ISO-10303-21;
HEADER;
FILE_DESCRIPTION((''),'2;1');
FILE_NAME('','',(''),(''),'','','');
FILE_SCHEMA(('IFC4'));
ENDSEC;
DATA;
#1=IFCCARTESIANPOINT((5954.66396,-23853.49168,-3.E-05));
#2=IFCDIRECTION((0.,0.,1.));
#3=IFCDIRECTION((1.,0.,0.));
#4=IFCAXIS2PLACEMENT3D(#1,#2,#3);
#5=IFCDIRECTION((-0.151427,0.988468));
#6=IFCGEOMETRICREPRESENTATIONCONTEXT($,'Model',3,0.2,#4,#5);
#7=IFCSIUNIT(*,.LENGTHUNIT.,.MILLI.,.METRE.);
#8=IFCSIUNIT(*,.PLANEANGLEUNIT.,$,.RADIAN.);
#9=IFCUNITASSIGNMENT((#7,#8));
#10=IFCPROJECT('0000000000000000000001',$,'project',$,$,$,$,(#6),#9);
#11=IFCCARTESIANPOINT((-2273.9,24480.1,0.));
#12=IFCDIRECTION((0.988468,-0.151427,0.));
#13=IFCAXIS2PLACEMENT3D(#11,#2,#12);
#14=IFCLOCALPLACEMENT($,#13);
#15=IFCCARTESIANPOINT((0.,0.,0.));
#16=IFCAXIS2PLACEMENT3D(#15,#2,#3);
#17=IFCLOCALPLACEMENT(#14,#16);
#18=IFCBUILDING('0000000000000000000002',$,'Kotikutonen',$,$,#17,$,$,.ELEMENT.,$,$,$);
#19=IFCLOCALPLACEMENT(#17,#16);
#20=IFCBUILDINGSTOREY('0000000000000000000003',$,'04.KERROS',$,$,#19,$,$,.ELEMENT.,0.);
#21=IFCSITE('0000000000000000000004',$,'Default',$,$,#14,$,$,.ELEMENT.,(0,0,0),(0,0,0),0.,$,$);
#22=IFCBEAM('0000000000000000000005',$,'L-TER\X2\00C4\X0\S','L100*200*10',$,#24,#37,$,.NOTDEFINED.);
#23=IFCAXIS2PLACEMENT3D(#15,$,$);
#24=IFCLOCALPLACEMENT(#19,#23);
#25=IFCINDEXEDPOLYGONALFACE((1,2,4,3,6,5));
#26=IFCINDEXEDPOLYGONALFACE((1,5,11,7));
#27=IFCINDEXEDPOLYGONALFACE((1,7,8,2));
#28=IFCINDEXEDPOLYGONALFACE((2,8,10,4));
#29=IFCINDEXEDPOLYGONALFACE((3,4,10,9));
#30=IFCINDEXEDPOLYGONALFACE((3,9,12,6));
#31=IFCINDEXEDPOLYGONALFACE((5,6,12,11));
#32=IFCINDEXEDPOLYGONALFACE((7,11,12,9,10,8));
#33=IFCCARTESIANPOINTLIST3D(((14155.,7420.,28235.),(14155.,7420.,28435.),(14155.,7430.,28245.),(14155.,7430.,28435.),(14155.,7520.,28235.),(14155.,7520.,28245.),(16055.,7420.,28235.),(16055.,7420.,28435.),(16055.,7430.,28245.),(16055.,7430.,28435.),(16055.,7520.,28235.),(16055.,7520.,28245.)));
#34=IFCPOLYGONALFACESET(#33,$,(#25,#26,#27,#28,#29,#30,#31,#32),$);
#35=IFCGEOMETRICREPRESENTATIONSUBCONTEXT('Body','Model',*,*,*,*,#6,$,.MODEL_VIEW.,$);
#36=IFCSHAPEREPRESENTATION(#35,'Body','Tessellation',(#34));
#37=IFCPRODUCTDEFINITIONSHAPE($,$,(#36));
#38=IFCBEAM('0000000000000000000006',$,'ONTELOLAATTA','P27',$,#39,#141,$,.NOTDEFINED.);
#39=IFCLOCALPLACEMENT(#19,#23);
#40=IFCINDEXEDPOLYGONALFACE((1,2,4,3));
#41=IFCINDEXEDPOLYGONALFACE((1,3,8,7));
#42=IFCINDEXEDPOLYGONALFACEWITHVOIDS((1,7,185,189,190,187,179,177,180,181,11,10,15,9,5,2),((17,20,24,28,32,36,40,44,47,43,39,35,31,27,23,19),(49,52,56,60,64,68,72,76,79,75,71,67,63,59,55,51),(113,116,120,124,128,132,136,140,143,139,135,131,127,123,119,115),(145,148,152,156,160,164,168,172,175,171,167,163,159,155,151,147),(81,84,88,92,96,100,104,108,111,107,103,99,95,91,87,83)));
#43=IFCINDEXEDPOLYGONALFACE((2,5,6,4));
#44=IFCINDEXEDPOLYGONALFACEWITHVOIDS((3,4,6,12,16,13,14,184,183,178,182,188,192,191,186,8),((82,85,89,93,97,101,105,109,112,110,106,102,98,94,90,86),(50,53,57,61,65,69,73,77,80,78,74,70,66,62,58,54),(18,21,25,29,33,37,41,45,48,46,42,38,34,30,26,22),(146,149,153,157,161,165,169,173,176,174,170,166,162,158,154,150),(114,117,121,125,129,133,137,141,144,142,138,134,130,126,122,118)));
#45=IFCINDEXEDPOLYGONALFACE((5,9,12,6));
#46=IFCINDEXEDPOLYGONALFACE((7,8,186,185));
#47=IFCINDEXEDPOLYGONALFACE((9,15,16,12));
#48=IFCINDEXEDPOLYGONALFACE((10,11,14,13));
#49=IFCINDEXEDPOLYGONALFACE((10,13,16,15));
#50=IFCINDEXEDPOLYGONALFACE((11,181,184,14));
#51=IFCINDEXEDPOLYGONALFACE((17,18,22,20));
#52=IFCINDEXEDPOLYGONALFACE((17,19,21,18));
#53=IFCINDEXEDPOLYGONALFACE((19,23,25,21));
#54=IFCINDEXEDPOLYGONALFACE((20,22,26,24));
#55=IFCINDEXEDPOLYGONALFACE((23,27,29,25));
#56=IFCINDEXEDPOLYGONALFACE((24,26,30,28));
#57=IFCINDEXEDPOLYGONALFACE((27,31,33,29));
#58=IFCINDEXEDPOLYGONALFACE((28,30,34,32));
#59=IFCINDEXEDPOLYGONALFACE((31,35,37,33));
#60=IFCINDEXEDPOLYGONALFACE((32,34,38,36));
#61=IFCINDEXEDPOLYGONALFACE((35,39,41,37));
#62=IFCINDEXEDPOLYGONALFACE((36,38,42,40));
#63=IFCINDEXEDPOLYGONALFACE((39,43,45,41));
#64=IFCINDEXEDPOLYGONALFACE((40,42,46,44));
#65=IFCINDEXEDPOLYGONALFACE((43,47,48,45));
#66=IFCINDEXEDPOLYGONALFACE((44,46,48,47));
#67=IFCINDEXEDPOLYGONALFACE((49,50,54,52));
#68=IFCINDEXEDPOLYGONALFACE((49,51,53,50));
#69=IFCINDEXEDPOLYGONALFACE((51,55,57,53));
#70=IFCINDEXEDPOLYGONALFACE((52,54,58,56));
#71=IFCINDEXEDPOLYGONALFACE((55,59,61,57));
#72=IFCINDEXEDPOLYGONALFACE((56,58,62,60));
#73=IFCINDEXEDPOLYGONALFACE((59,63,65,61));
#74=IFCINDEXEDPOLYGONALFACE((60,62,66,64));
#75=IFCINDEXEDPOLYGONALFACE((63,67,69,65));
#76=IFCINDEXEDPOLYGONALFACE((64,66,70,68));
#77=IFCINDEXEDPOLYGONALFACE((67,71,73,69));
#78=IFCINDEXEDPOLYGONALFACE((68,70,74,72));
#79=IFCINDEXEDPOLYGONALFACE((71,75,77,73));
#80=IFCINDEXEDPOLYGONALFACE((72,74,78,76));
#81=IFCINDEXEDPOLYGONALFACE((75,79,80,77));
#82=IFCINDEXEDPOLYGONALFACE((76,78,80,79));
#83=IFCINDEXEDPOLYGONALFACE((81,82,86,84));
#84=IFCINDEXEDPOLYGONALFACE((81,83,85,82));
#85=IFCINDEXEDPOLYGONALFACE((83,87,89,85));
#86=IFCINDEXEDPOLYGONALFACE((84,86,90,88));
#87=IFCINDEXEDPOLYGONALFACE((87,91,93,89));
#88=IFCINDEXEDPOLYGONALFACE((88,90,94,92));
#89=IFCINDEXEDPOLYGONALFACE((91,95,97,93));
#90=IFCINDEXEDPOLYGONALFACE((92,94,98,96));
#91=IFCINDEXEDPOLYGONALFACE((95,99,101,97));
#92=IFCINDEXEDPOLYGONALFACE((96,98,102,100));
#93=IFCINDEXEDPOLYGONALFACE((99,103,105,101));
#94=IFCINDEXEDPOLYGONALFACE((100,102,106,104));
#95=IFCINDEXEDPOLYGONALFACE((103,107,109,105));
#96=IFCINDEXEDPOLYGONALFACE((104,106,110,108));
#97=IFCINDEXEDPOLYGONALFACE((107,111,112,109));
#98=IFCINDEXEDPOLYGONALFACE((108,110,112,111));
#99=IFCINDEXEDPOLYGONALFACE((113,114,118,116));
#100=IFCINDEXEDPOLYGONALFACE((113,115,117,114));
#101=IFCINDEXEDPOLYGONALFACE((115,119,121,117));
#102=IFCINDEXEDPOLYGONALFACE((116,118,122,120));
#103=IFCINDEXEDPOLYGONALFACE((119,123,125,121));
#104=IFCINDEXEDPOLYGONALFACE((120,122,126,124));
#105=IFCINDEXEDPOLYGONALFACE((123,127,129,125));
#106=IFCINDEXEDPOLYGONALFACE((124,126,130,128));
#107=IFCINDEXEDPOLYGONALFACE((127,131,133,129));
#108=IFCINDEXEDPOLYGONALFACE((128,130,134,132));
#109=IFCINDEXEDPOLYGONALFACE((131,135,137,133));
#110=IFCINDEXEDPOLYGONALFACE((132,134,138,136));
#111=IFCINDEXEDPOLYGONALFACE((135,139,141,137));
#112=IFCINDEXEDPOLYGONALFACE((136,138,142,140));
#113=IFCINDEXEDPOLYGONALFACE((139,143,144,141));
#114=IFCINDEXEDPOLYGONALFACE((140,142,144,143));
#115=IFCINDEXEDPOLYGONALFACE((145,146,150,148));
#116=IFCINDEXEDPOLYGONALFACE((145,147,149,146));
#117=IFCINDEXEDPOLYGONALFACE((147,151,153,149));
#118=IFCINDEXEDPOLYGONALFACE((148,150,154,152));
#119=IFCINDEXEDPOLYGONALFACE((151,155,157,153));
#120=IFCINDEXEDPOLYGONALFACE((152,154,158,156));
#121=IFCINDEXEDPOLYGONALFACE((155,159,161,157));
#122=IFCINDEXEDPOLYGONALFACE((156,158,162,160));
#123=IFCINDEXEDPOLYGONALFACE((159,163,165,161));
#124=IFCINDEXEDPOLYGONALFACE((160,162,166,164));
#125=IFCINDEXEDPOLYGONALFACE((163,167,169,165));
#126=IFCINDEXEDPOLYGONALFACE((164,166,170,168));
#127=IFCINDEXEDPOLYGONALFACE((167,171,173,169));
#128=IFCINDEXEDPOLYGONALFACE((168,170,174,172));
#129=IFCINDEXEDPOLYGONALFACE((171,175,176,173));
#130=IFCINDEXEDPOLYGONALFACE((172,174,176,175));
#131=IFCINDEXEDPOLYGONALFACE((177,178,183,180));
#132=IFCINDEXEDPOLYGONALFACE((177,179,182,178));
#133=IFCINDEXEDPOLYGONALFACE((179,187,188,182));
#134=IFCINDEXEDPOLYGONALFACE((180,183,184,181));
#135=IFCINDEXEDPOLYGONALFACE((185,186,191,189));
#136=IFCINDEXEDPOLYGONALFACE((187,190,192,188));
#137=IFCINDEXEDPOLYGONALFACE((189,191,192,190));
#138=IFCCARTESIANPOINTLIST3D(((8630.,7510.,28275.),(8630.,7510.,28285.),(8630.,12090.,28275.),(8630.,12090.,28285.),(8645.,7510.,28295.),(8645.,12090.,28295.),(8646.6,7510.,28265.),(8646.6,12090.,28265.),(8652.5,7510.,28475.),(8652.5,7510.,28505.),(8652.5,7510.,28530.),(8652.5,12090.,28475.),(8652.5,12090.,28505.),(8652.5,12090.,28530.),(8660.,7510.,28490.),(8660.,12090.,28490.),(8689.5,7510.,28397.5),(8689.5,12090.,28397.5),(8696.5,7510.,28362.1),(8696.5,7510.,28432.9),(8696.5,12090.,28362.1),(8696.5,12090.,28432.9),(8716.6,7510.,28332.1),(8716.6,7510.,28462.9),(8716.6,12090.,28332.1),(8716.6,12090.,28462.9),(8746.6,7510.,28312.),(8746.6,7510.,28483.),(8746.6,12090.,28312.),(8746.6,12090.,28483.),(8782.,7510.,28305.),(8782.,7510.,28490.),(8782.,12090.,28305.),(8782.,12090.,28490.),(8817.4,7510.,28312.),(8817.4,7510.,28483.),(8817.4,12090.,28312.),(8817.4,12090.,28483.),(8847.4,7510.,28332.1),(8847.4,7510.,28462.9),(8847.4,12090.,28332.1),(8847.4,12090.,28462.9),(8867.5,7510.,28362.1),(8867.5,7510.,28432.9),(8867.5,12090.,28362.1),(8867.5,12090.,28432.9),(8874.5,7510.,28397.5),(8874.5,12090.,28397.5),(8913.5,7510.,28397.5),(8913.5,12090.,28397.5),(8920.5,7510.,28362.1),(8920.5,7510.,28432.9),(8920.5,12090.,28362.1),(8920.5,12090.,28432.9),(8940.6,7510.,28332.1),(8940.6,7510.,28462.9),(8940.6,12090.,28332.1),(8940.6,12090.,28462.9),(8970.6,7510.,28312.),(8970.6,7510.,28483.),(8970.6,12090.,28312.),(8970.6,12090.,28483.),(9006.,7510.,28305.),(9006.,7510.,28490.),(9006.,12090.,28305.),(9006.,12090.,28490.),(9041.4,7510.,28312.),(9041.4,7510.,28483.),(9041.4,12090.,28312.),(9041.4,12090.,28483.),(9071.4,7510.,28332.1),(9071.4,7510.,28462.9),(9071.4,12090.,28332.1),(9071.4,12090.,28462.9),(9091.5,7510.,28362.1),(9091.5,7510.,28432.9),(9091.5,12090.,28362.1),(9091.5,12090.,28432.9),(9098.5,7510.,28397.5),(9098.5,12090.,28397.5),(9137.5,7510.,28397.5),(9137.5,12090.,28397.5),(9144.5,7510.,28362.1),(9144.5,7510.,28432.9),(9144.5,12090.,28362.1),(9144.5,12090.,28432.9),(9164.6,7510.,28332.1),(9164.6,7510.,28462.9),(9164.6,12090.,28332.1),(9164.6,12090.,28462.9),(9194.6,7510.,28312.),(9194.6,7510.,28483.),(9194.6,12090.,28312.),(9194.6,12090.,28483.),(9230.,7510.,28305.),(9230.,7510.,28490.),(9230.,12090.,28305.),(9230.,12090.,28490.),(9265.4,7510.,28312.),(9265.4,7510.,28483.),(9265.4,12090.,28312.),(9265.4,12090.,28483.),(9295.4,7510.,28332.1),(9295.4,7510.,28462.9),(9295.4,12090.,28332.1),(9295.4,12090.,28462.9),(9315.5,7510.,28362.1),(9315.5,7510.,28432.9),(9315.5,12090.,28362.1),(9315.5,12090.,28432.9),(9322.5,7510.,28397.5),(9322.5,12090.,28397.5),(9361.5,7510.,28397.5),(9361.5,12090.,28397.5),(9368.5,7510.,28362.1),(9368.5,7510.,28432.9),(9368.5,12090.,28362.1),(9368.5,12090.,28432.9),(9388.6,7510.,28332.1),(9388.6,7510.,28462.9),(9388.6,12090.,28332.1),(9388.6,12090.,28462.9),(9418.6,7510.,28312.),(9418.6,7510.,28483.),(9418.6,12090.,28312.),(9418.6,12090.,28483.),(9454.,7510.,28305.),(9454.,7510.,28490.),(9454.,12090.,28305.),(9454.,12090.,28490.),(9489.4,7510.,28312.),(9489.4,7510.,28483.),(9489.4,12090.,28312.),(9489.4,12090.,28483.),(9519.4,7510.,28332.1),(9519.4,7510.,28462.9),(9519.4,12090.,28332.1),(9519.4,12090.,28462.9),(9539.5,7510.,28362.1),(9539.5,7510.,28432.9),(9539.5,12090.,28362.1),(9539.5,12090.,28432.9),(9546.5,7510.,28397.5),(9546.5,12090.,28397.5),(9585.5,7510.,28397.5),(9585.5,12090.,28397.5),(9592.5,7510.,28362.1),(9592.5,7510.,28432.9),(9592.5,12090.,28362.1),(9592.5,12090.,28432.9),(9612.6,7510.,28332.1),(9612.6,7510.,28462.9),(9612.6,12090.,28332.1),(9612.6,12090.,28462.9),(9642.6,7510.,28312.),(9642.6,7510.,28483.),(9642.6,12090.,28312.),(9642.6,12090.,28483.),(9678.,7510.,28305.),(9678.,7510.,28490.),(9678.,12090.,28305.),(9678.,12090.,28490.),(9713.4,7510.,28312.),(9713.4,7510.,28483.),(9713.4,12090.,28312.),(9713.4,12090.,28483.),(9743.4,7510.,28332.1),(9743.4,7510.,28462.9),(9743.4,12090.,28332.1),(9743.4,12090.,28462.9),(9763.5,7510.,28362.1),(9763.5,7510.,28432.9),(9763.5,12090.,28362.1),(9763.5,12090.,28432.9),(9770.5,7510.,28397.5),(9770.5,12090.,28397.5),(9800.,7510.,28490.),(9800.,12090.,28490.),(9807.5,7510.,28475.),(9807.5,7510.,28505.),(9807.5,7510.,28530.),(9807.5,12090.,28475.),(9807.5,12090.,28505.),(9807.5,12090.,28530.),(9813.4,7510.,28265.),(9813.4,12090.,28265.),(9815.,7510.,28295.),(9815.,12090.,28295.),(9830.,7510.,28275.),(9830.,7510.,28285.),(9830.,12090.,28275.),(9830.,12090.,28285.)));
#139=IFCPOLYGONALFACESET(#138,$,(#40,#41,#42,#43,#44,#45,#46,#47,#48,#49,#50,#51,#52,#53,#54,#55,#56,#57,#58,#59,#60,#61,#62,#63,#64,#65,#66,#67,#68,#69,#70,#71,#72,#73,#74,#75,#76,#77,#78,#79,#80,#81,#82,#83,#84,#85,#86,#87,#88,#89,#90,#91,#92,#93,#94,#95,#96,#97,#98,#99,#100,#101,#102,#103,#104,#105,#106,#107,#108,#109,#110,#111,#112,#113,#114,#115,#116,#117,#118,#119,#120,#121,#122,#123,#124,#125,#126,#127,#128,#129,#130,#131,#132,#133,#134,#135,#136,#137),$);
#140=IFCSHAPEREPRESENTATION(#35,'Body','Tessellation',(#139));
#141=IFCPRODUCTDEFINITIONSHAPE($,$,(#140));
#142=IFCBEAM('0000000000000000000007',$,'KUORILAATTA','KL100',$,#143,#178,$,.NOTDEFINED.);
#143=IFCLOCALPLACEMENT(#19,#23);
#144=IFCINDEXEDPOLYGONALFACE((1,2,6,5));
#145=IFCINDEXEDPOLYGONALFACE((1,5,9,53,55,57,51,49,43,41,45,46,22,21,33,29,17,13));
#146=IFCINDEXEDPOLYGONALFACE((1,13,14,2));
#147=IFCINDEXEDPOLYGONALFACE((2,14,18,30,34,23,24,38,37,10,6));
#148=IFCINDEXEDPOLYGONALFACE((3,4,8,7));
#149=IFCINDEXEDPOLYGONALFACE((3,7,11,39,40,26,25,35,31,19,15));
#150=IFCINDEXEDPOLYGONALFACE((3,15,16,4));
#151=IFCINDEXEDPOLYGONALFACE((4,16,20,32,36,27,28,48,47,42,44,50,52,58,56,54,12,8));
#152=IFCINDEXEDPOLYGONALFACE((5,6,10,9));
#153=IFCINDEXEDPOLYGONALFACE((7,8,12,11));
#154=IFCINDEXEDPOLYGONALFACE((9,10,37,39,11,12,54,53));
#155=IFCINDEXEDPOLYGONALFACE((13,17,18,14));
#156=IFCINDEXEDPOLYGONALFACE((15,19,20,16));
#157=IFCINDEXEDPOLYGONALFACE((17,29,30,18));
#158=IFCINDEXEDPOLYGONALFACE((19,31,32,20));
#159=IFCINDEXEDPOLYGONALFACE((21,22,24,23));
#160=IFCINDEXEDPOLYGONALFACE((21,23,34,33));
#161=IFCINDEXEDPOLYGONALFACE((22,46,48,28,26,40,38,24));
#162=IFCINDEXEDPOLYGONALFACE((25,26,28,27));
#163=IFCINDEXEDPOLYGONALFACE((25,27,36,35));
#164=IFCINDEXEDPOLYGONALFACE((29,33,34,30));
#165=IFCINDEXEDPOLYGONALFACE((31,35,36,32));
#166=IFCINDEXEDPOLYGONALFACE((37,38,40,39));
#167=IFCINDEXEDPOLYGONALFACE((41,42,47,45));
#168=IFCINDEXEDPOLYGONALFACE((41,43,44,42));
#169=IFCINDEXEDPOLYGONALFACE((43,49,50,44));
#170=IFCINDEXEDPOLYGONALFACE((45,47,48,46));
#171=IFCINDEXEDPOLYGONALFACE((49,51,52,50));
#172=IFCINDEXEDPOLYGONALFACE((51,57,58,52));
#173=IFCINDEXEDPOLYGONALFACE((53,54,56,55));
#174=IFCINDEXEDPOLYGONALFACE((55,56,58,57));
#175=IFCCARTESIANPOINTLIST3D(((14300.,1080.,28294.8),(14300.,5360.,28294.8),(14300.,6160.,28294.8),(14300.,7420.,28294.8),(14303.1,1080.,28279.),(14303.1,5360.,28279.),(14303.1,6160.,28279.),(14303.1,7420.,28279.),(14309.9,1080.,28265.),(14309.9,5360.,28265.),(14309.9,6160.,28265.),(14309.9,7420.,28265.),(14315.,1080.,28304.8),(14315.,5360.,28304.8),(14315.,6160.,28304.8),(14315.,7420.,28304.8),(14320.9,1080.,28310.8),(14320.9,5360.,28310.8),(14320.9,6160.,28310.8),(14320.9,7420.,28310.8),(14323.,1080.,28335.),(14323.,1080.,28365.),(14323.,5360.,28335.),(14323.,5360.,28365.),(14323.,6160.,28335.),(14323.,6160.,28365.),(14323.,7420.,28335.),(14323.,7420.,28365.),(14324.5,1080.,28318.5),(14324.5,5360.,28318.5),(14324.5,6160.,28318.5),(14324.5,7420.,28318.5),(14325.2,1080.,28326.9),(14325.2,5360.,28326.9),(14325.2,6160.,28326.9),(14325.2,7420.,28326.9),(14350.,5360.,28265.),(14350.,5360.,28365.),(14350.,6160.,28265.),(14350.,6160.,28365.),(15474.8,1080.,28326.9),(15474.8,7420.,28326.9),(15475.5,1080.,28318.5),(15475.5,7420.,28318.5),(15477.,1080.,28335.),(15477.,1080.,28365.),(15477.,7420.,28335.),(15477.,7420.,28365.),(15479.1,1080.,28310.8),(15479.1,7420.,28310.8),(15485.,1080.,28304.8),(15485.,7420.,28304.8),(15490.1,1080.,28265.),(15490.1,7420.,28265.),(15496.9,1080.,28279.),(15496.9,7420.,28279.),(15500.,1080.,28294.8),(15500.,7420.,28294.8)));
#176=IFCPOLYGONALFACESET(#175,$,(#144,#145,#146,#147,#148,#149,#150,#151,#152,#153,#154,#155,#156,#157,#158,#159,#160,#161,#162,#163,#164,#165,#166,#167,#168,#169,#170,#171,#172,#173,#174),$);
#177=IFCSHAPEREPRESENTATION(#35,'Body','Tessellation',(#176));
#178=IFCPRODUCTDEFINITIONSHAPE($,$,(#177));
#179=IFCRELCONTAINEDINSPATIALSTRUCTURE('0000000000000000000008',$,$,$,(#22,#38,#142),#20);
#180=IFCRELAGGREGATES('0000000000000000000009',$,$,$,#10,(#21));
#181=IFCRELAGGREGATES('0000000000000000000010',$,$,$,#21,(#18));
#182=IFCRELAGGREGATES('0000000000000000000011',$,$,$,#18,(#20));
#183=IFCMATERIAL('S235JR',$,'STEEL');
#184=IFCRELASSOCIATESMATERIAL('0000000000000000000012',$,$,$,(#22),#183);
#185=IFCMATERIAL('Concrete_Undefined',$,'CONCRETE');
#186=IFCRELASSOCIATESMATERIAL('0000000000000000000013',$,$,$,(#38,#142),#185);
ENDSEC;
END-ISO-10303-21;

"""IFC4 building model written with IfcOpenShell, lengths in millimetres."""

from ifc_helpers import new_model, si_unit, direction, frame, origin_with_axes, place, context, subcontext, project, spatial, line, indexed_curve, outline, extrude, material, element, save


model = new_model("IFC4")

# Units and contexts
model_context = context("Model", 3, precision=0.2, world=frame((5954.66396, -23853.49168, -3e-05), z_axis=(0.0, 0.0, 1.0), x_axis=(1.0, 0.0, 0.0)), true_north=direction((-0.151427, 0.988468)))
body_context = subcontext(model_context, "Body", "Model", "MODEL_VIEW")
ifc_project = project(units=[si_unit("LENGTHUNIT", "METRE", prefix="MILLI"), si_unit("PLANEANGLEUNIT", "RADIAN")], contexts=[model_context])

# Site, building, storey
site_placement = place(None, frame((-2273.9, 24480.1, 0.0), z_axis=(0.0, 0.0, 1.0), x_axis=(0.988468, -0.151427, 0.0)))
site = spatial("IfcSite", under=ifc_project, at=site_placement, Name="Default", CompositionType="ELEMENT", RefLatitude=(0, 0, 0), RefLongitude=(0, 0, 0), RefElevation=0.0)
building_placement = place(site_placement, origin_with_axes())
building = spatial("IfcBuilding", under=site, at=building_placement, Name="Kotikutonen", CompositionType="ELEMENT")
storey_placement = place(building_placement, origin_with_axes())
storey = spatial("IfcBuildingStorey", under=building, at=storey_placement, Name="04.KERROS", CompositionType="ELEMENT", Elevation=0.0)

# Beams
ifc_material_1 = material(Name="Concrete_Undefined", Category="CONCRETE")
ifc_material_2 = material(Name="S235JR", Category="STEEL")
for number, where, z_axis, x_axis, name in (
    (1, (14155.0, 7470.0, 28335.0), (0.0, 0.0, 1.0), (1.0, 0.0, 0.0), "L-TERÄS"),
):
    element("IfcBeam", number, at=place(storey_placement, frame(where, z_axis=z_axis, x_axis=x_axis)), inside=storey, material=ifc_material_2, Name=name, Description="L100*200*10", PredefinedType="NOTDEFINED", context=body_context, shape_type="SolidModel", body=[
        extrude(outline(indexed_curve([(-100.0, -50.0), (100.0, -50.0), (100.0, -40.0), (-90.0, -40.0), (-90.0, 50.0), (-100.0, 50.0)], segments=[line(1, 2, 3, 4, 5, 6, 1)])), frame((0.0, 0.0, 0.0), z_axis=(-1.0, 0.0, 0.0), x_axis=(0.0, 0.0, 1.0)), (0.0, 0.0, -1.0), 1900.0),
    ])
beam_1_placement = place(storey_placement, frame((9230.0, 12090.0, 28397.5), z_axis=(-1.0, 0.0, 0.0), x_axis=(0.0, -1.0, 0.0)))
element("IfcBeam", 2, at=beam_1_placement, inside=storey, material=ifc_material_1, Name="ONTELOLAATTA", Description="P27", PredefinedType="NOTDEFINED", context=body_context, shape_type="SolidModel", body=[
    extrude(outline(indexed_curve([(-600.0, -122.5), (-583.4, -132.5), (583.4, -132.5), (600.0, -122.5), (600.0, -112.5), (585.0, -102.5), (577.5, 77.5), (570.0, 92.5), (577.5, 107.5), (577.5, 132.5), (-577.5, 132.5), (-577.5, 107.5), (-570.0, 92.5), (-577.5, 77.5), (-585.0, -102.5), (-600.0, -112.5)], segments=[line(1, 2, 3, 4, 5, 6, 7, 8, 9, 10, 11, 12, 13, 14, 15, 16, 1)]), holes=[indexed_curve([(-448.0, -92.5), (-483.4, -85.5), (-513.4, -65.4), (-533.5, -35.4), (-540.5, 0.0), (-533.5, 35.4), (-513.4, 65.4), (-483.4, 85.5), (-448.0, 92.5), (-412.6, 85.5), (-382.6, 65.4), (-362.5, 35.4), (-355.5, 0.0), (-362.5, -35.4), (-382.6, -65.4), (-412.6, -85.5)], segments=[line(1, 2, 3, 4, 5, 6, 7, 8, 9, 10, 11, 12, 13, 14, 15, 16, 1)]), indexed_curve([(-224.0, -92.5), (-259.4, -85.5), (-289.4, -65.4), (-309.5, -35.4), (-316.5, 0.0), (-309.5, 35.4), (-289.4, 65.4), (-259.4, 85.5), (-224.0, 92.5), (-188.6, 85.5), (-158.6, 65.4), (-138.5, 35.4), (-131.5, 0.0), (-138.5, -35.4), (-158.6, -65.4), (-188.6, -85.5)], segments=[line(1, 2, 3, 4, 5, 6, 7, 8, 9, 10, 11, 12, 13, 14, 15, 16, 1)]), indexed_curve([(0.0, -92.5), (-35.4, -85.5), (-65.4, -65.4), (-85.5, -35.4), (-92.5, 0.0), (-85.5, 35.4), (-65.4, 65.4), (-35.4, 85.5), (0.0, 92.5), (35.4, 85.5), (65.4, 65.4), (85.5, 35.4), (92.5, 0.0), (85.5, -35.4), (65.4, -65.4), (35.4, -85.5)], segments=[line(1, 2, 3, 4, 5, 6, 7, 8, 9, 10, 11, 12, 13, 14, 15, 16, 1)]), indexed_curve([(224.0, -92.5), (188.6, -85.5), (158.6, -65.4), (138.5, -35.4), (131.5, 0.0), (138.5, 35.4), (158.6, 65.4), (188.6, 85.5), (224.0, 92.5), (259.4, 85.5), (289.4, 65.4), (309.5, 35.4), (316.5, 0.0), (309.5, -35.4), (289.4, -65.4), (259.4, -85.5)], segments=[line(1, 2, 3, 4, 5, 6, 7, 8, 9, 10, 11, 12, 13, 14, 15, 16, 1)]), indexed_curve([(448.0, -92.5), (412.6, -85.5), (382.6, -65.4), (362.5, -35.4), (355.5, 0.0), (362.5, 35.4), (382.6, 65.4), (412.6, 85.5), (448.0, 92.5), (483.4, 85.5), (513.4, 65.4), (533.5, 35.4), (540.5, 0.0), (533.5, -35.4), (513.4, -65.4), (483.4, -85.5)], segments=[line(1, 2, 3, 4, 5, 6, 7, 8, 9, 10, 11, 12, 13, 14, 15, 16, 1)])]), frame((0.0, 0.0, 0.0), z_axis=(-1.0, 0.0, 0.0), x_axis=(0.0, 0.0, 1.0)), (0.0, 0.0, -1.0), 4580.0),
])

# Beam, voiding feature
beam_2_placement = place(storey_placement, frame((14900.0, 7420.0, 28315.0), z_axis=(-1.0, 0.0, 0.0), x_axis=(0.0, -1.0, 0.0)))
beam_2 = element("IfcBeam", 3, at=beam_2_placement, inside=storey, material=ifc_material_1, Name="KUORILAATTA", Description="KL100", PredefinedType="NOTDEFINED", context=body_context, shape_type="SolidModel", body=[
    extrude(outline(indexed_curve([(-596.9, -36.0), (-590.1, -50.0), (590.1, -50.0), (596.9, -36.0), (600.0, -20.2), (585.0, -10.2), (579.1, -4.2), (575.5, 3.5), (574.8, 11.9), (577.0, 20.0), (577.0, 50.0), (-577.0, 50.0), (-577.0, 20.0), (-574.8, 11.9), (-575.5, 3.5), (-579.1, -4.2), (-585.0, -10.2), (-600.0, -20.2)], segments=[line(1, 2, 3, 4, 5, 6, 7, 8, 9, 10, 11, 12, 13, 14, 15, 16, 17, 18, 1)])), frame((0.0, 0.0, 0.0), z_axis=(-1.0, 0.0, 0.0), x_axis=(0.0, 0.0, 1.0)), (0.0, 0.0, -1.0), 6340.0),
])
voiding_feature_1_placement = place(beam_2_placement, frame((1260.0, 0.0, 550.0), z_axis=(0.0, 1.0, 0.0), x_axis=(0.0, 0.0, 1.0)))
element("IfcVoidingFeature", 4, at=voiding_feature_1_placement, cuts=beam_2, Name="Opening", PredefinedType="HOLE", context=body_context, shape_type="SolidModel", body=[
    extrude(outline(indexed_curve([(0.0, 0.0), (300.0, 0.0), (300.0, 800.0), (0.0, 800.0)], segments=[line(1, 2, 3, 4, 1)])), frame((0.0, 0.0, 125.0), z_axis=(0.0, 0.0, 1.0), x_axis=(1.0, 0.0, 0.0)), (0.0, 0.0, -1.0), 250.0),
])

save(model, "model.ifc")
